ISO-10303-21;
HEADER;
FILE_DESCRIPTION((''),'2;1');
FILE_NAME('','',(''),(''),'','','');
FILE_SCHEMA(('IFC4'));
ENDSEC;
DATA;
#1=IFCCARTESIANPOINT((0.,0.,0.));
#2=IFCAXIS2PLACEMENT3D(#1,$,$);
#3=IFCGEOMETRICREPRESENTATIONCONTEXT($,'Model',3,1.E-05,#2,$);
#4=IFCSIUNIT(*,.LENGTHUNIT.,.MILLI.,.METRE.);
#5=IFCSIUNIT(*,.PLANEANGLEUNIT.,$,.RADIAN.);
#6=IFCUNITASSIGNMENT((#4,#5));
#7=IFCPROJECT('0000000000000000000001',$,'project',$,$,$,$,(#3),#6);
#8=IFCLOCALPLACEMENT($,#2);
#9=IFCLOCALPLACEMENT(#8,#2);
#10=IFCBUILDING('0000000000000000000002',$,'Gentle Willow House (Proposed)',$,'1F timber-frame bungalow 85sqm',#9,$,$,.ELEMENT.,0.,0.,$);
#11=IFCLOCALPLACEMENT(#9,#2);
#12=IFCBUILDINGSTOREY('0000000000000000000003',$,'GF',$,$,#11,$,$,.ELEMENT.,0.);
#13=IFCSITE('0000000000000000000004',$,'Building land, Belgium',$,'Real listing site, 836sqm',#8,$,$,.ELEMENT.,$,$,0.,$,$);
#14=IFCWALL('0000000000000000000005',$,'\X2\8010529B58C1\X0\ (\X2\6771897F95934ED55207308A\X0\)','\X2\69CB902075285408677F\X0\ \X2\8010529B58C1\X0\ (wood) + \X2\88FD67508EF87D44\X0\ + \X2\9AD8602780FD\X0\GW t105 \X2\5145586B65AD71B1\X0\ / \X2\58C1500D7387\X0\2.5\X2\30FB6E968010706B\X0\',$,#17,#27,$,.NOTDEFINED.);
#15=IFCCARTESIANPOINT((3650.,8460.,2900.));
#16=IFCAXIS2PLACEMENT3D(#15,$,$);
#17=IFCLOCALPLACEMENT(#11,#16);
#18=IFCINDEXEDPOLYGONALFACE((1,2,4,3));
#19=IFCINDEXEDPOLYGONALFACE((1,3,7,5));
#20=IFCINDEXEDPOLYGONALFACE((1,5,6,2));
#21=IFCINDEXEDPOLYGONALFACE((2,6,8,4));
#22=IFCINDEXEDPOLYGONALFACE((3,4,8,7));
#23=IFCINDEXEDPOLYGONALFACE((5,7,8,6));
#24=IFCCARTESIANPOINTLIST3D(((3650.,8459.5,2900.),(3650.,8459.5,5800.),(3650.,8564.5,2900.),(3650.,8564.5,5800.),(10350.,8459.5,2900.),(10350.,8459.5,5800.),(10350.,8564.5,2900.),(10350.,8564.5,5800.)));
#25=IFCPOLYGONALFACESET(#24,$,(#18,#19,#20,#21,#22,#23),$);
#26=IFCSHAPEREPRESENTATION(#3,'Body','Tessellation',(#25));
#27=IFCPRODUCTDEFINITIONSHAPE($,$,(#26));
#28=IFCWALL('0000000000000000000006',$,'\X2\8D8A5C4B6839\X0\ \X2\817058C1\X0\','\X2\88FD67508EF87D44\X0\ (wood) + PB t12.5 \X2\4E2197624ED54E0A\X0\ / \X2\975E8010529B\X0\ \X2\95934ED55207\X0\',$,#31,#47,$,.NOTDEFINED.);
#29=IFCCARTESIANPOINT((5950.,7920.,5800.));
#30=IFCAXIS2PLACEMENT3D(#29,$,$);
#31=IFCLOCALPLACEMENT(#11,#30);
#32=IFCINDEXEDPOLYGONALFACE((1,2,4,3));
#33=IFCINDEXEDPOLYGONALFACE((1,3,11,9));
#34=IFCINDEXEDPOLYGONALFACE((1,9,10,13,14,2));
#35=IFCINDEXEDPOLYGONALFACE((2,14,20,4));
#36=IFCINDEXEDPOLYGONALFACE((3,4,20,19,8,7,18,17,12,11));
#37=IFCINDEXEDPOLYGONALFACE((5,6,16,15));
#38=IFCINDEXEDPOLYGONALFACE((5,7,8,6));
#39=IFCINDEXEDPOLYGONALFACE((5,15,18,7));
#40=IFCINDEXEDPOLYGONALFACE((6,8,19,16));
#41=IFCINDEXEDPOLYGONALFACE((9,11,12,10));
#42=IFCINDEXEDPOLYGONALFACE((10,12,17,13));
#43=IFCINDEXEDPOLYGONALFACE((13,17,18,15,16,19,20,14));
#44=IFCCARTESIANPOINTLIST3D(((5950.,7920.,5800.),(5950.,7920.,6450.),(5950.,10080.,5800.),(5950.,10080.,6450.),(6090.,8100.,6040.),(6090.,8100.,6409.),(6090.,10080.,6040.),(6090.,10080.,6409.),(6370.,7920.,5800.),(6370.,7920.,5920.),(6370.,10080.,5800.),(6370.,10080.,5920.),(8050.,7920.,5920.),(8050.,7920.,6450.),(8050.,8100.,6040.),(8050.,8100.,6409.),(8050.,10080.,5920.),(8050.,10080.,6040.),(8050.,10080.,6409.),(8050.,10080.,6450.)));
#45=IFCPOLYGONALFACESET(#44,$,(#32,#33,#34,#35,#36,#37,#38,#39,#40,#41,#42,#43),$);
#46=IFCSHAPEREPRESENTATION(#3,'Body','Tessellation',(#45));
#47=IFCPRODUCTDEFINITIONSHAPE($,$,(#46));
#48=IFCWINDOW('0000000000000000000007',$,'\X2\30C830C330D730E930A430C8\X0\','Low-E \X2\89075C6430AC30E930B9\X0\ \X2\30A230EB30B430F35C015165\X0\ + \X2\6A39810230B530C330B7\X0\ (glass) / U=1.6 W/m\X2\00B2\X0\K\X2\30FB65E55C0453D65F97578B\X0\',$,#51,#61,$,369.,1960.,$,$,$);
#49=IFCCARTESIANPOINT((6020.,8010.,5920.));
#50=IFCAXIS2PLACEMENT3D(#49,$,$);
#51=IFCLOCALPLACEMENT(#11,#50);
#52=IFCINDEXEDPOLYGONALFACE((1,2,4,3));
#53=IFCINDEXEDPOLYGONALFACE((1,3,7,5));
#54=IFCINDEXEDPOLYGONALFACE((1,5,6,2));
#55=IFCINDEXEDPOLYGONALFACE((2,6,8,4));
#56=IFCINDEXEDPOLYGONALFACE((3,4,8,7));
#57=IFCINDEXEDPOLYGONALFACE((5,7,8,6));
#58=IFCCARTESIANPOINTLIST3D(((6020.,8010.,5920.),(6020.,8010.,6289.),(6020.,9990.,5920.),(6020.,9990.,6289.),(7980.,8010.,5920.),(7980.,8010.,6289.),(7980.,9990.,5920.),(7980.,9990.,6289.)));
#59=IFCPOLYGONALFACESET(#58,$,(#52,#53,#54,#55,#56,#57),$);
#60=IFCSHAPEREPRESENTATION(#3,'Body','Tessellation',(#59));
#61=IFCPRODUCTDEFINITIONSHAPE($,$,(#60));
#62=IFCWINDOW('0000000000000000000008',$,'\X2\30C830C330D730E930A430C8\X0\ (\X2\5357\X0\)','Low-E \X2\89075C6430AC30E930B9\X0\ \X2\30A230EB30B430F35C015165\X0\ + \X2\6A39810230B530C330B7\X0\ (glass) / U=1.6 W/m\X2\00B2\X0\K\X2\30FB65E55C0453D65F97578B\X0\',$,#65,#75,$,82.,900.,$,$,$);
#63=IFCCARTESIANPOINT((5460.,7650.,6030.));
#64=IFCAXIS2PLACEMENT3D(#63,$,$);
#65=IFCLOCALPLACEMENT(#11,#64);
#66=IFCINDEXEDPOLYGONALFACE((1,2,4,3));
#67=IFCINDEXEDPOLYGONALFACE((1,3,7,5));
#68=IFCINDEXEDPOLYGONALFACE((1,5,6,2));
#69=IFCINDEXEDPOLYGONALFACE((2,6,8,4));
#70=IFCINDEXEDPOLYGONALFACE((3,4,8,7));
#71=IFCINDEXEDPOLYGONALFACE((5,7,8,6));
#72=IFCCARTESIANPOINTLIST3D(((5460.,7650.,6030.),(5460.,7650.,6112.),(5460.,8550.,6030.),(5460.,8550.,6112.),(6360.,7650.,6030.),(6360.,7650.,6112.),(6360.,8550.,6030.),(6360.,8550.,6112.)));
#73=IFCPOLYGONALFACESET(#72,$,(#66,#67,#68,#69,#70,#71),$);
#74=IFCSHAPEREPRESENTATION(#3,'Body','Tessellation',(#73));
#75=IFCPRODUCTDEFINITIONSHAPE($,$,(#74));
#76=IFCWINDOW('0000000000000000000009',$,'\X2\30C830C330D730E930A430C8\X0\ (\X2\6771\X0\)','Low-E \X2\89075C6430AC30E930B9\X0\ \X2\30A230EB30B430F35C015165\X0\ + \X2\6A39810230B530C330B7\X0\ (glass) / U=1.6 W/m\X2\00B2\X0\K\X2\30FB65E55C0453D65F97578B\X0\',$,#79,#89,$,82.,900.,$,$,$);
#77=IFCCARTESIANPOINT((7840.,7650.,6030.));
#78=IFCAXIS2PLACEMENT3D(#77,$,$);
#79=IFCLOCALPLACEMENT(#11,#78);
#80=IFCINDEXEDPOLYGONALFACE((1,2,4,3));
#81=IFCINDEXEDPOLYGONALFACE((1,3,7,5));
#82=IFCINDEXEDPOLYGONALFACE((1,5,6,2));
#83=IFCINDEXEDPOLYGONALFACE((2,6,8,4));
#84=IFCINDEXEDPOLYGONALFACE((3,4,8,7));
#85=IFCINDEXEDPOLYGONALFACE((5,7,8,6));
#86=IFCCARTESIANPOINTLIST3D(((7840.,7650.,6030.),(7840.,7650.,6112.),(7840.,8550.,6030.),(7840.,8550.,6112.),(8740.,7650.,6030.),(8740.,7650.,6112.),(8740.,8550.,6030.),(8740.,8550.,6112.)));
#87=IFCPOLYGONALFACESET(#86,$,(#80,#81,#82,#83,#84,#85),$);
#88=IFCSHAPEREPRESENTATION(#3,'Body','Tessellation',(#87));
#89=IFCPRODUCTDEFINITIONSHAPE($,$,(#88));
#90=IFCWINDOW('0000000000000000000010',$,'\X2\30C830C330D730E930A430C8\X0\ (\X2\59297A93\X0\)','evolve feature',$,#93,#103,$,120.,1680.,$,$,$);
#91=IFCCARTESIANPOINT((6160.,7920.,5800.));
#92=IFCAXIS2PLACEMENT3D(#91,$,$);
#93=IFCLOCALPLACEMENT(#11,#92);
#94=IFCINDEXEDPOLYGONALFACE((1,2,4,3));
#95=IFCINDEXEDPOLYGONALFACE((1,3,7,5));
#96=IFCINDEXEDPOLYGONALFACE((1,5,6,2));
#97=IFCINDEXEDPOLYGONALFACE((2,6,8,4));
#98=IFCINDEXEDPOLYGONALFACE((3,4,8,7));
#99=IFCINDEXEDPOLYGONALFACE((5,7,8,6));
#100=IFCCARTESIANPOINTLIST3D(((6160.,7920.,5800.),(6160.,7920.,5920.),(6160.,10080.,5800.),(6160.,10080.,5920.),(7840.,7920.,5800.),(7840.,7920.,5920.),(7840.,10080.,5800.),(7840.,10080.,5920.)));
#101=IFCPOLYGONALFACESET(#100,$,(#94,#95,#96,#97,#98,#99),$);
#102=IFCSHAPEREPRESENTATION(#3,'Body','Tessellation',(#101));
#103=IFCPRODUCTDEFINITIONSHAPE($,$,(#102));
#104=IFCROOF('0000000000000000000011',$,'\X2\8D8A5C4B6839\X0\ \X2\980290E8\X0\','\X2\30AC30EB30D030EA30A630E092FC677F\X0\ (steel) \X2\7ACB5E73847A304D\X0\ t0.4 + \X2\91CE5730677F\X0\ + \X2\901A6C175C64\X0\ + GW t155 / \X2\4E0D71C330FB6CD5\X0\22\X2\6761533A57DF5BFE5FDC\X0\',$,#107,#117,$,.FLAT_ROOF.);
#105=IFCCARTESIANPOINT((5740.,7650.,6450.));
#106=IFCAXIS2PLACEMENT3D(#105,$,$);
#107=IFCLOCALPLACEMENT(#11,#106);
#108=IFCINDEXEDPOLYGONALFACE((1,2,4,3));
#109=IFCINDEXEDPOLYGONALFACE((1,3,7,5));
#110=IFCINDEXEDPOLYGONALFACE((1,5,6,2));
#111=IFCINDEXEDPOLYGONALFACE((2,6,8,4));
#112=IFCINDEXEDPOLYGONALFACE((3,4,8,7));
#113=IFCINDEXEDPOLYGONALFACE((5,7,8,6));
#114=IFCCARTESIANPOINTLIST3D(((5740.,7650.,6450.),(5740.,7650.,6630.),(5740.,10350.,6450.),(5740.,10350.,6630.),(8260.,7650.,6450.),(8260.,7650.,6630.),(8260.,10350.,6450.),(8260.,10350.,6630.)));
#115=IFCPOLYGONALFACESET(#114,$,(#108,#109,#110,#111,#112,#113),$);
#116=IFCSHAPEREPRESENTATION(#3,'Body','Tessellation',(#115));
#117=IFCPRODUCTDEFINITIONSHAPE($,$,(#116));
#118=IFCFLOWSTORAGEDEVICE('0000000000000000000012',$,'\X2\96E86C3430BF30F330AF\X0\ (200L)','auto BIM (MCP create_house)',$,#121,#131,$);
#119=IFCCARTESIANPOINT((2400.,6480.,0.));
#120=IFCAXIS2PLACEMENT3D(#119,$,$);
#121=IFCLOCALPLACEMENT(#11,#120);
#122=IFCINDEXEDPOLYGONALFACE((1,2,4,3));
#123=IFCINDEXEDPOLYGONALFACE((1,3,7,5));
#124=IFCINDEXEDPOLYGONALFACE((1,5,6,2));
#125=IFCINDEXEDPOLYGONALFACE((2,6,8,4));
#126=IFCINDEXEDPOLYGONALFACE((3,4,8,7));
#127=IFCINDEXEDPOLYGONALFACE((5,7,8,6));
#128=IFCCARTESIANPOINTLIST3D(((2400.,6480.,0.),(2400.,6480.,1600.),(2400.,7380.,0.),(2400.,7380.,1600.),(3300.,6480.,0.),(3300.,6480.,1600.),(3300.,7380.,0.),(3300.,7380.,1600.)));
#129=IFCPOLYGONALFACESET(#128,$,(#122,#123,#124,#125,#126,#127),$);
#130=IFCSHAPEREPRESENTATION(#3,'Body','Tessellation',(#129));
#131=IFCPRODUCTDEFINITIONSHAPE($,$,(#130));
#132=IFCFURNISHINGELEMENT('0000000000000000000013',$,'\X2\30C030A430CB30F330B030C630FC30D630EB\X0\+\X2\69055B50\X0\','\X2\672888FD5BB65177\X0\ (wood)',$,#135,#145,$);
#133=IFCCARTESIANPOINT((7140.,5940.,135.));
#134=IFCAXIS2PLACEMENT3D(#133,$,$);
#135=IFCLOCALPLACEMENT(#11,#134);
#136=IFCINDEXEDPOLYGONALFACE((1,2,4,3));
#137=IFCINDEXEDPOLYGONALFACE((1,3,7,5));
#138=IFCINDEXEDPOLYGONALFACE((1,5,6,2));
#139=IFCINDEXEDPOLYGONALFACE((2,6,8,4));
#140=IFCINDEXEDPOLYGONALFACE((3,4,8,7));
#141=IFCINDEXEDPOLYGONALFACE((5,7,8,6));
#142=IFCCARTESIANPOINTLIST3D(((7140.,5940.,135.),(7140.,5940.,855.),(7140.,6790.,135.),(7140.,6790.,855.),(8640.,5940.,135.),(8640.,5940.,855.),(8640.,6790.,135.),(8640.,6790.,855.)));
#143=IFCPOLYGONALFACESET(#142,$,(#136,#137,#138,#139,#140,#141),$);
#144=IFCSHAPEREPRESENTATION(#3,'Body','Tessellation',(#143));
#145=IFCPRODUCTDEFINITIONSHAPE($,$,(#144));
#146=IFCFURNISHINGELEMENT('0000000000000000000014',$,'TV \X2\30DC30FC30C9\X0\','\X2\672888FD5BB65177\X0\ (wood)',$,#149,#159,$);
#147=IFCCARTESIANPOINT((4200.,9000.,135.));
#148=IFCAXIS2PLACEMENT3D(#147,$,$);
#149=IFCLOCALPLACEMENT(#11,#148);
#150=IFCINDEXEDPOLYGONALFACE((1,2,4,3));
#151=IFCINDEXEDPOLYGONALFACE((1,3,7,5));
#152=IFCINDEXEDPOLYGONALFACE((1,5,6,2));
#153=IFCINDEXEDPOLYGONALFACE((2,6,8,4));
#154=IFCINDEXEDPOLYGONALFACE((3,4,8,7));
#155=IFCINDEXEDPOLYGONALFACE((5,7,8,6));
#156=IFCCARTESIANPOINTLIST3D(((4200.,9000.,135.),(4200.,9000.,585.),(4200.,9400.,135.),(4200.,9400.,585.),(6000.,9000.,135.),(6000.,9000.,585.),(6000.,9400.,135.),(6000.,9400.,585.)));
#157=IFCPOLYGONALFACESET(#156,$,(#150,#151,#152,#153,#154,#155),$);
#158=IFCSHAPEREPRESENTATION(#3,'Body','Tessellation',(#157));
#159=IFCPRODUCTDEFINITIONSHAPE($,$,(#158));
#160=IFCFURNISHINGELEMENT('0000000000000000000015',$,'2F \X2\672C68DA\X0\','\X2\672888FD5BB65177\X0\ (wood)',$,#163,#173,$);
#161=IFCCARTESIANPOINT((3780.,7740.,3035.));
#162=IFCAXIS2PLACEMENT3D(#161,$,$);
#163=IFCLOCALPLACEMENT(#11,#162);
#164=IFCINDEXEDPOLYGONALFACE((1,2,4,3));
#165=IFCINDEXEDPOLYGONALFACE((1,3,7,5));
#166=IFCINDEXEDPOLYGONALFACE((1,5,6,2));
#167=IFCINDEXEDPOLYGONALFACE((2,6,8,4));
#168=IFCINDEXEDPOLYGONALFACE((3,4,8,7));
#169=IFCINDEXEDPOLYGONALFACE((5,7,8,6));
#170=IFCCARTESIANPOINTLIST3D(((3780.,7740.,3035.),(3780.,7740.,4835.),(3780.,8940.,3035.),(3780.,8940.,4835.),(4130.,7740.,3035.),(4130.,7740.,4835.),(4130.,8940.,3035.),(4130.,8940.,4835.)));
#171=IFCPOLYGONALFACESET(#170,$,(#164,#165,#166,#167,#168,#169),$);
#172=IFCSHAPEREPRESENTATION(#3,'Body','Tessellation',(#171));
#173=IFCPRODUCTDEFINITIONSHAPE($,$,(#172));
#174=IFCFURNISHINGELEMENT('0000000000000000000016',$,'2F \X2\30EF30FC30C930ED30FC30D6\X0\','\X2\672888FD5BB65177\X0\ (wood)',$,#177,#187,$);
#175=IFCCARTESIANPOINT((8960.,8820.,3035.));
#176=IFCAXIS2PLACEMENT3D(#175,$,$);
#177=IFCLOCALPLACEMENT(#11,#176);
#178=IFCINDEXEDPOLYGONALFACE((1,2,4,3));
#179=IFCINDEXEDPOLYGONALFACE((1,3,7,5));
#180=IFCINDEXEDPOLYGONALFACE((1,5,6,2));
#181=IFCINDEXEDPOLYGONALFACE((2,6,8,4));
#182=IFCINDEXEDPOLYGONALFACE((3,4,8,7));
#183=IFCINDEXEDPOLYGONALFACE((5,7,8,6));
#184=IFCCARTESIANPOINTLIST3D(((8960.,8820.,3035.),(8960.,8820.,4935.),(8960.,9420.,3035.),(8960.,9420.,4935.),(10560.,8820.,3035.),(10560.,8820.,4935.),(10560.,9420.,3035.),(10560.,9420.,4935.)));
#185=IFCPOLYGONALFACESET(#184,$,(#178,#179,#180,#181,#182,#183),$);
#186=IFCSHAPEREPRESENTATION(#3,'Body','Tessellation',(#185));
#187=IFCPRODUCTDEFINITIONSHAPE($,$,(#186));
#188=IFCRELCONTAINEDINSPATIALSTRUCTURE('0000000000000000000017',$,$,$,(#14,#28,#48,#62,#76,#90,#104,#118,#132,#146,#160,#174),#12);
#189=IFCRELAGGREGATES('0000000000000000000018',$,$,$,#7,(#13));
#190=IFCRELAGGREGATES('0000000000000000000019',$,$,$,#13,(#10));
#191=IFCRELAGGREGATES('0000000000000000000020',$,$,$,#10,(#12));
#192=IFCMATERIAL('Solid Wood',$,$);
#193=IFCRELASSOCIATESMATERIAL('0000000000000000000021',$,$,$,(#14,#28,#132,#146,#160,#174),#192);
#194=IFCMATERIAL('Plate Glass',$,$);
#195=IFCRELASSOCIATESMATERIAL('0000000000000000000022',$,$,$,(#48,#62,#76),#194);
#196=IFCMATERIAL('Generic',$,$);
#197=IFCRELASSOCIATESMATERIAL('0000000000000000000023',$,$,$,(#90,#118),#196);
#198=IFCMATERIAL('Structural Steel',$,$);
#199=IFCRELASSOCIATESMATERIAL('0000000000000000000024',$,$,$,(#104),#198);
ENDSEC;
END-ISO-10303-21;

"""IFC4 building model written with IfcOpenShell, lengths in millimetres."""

from ifc_helpers import new_model, si_unit, frame, frame_2d, origin, place, context, project, spatial, rectangle, extrude, material, element, fill, save


model = new_model("IFC4")

# Units and contexts
model_context = context("Model", 3, precision=1e-05, world=origin())
ifc_project = project(units=[si_unit("LENGTHUNIT", "METRE", prefix="MILLI"), si_unit("PLANEANGLEUNIT", "RADIAN")], contexts=[model_context])

# Site, building, storey
site_placement = place(None, origin())
site = spatial("IfcSite", under=ifc_project, at=site_placement, Name="Building land, Belgium", ObjectType="Real listing site, 836sqm", CompositionType="ELEMENT", RefElevation=0.0)
building_placement = place(site_placement, origin())
building = spatial("IfcBuilding", under=site, at=building_placement, Name="Gentle Willow House (Proposed)", ObjectType="1F timber-frame bungalow 85sqm", CompositionType="ELEMENT", ElevationOfRefHeight=0.0, ElevationOfTerrain=0.0)
storey_placement = place(building_placement, origin())
storey = spatial("IfcBuildingStorey", under=building, at=storey_placement, Name="GF", CompositionType="ELEMENT", Elevation=0.0)

# Wall
ifc_material_1 = material(Name="Solid Wood")
wall_1_placement = place(storey_placement, frame((3650.0, 8460.0, 2900.0)))
element("IfcWall", 1, at=wall_1_placement, inside=storey, material=ifc_material_1, Name="耐力壁 (東西間仕切り)", Description="構造用合板 耐力壁 (wood) + 製材軸組 + 高性能GW t105 充填断熱 / 壁倍率2.5・準耐火", PredefinedType="NOTDEFINED", context=model_context, shape_type="SweptSolid", body=[
    extrude(rectangle(XDim=6700.0, YDim=105.0, at=frame_2d((3350.0, 52.0))), frame((3650.0, 8460.0, 2900.0)), (0.0, 0.0, 1.0), 2900.0),
])

# Wall, openings, windows
wall_2_placement = place(storey_placement, frame((5950.0, 7920.0, 5800.0)))
wall_2 = element("IfcWall", 2, at=wall_2_placement, inside=storey, material=ifc_material_1, Name="越屋根 腰壁", Description="製材軸組 (wood) + PB t12.5 両面仕上 / 非耐力 間仕切", PredefinedType="NOTDEFINED", context=model_context, shape_type="SweptSolid", body=[
    extrude(rectangle(XDim=2100.0, YDim=2160.0, at=frame_2d((1050.0, 1080.0))), frame((5950.0, 7920.0, 5800.0)), (0.0, 0.0, 1.0), 650.0),
])
opening_1_placement = place(storey_placement, frame((6020.0, 8010.0, 5920.0)))
opening_1 = element("IfcOpeningElement", 3, at=opening_1_placement, cuts=wall_2, PredefinedType="NOTDEFINED", context=model_context, shape_type="SweptSolid", body=[
    extrude(rectangle(XDim=1960.0, YDim=1980.0, at=frame_2d((980.0, 990.0))), frame((6020.0, 8010.0, 5920.0)), (0.0, 0.0, 1.0), 369.0),
])
opening_2_placement = place(storey_placement, frame((5460.0, 7650.0, 6030.0)))
opening_2 = element("IfcOpeningElement", 4, at=opening_2_placement, cuts=wall_2, PredefinedType="NOTDEFINED", context=model_context, shape_type="SweptSolid", body=[
    extrude(rectangle(XDim=900.0, YDim=900.0, at=frame_2d((450.0, 450.0))), frame((5460.0, 7650.0, 6030.0)), (0.0, 0.0, 1.0), 82.0),
])
opening_3_placement = place(storey_placement, frame((7840.0, 7650.0, 6030.0)))
opening_3 = element("IfcOpeningElement", 5, at=opening_3_placement, cuts=wall_2, PredefinedType="NOTDEFINED", context=model_context, shape_type="SweptSolid", body=[
    extrude(rectangle(XDim=900.0, YDim=900.0, at=frame_2d((450.0, 450.0))), frame((7840.0, 7650.0, 6030.0)), (0.0, 0.0, 1.0), 82.0),
])
opening_4_placement = place(storey_placement, frame((6160.0, 7920.0, 5800.0)))
opening_4 = element("IfcOpeningElement", 6, at=opening_4_placement, cuts=wall_2, PredefinedType="NOTDEFINED", context=model_context, shape_type="SweptSolid", body=[
    extrude(rectangle(XDim=1680.0, YDim=2160.0, at=frame_2d((840.0, 1080.0))), frame((6160.0, 7920.0, 5800.0)), (0.0, 0.0, 1.0), 120.0),
])
ifc_material_2 = material(Name="Plate Glass")
window_1_placement = place(storey_placement, frame((6020.0, 8010.0, 5920.0)))
window_1 = element("IfcWindow", 7, at=window_1_placement, inside=storey, material=ifc_material_2, Name="トップライト", Description="Low-E 複層ガラス アルゴン封入 + 樹脂サッシ (glass) / U=1.6 W/m²K・日射取得型", OverallHeight=369.0, OverallWidth=1960.0, context=model_context, shape_type="SweptSolid", body=[
    extrude(rectangle(XDim=1960.0, YDim=1980.0, at=frame_2d((980.0, 990.0))), frame((6020.0, 8010.0, 5920.0)), (0.0, 0.0, 1.0), 369.0),
])
fill(opening_1, window_1)
window_2_placement = place(storey_placement, frame((5460.0, 7650.0, 6030.0)))
window_2 = element("IfcWindow", 8, at=window_2_placement, inside=storey, material=ifc_material_2, Name="トップライト (南)", Description="Low-E 複層ガラス アルゴン封入 + 樹脂サッシ (glass) / U=1.6 W/m²K・日射取得型", OverallHeight=82.0, OverallWidth=900.0, context=model_context, shape_type="SweptSolid", body=[
    extrude(rectangle(XDim=900.0, YDim=900.0, at=frame_2d((450.0, 450.0))), frame((5460.0, 7650.0, 6030.0)), (0.0, 0.0, 1.0), 82.0),
])
fill(opening_2, window_2)
window_3_placement = place(storey_placement, frame((7840.0, 7650.0, 6030.0)))
window_3 = element("IfcWindow", 9, at=window_3_placement, inside=storey, material=ifc_material_2, Name="トップライト (東)", Description="Low-E 複層ガラス アルゴン封入 + 樹脂サッシ (glass) / U=1.6 W/m²K・日射取得型", OverallHeight=82.0, OverallWidth=900.0, context=model_context, shape_type="SweptSolid", body=[
    extrude(rectangle(XDim=900.0, YDim=900.0, at=frame_2d((450.0, 450.0))), frame((7840.0, 7650.0, 6030.0)), (0.0, 0.0, 1.0), 82.0),
])
fill(opening_3, window_3)
ifc_material_3 = material(Name="Generic")
window_4_placement = place(storey_placement, frame((6160.0, 7920.0, 5800.0)))
window_4 = element("IfcWindow", 10, at=window_4_placement, inside=storey, material=ifc_material_3, Name="トップライト (天窓)", Description="evolve feature", OverallHeight=120.0, OverallWidth=1680.0, context=model_context, shape_type="SweptSolid", body=[
    extrude(rectangle(XDim=1680.0, YDim=2160.0, at=frame_2d((840.0, 1080.0))), frame((6160.0, 7920.0, 5800.0)), (0.0, 0.0, 1.0), 120.0),
])
fill(opening_4, window_4)

# Roof
ifc_material_4 = material(Name="Structural Steel")
roof_placement = place(storey_placement, frame((5740.0, 7650.0, 6450.0)))
element("IfcRoof", 11, at=roof_placement, inside=storey, material=ifc_material_4, Name="越屋根 頂部", Description="ガルバリウム鋼板 (steel) 立平葺き t0.4 + 野地板 + 通気層 + GW t155 / 不燃・法22条区域対応", PredefinedType="FLAT_ROOF", context=model_context, shape_type="SweptSolid", body=[
    extrude(rectangle(XDim=2520.0, YDim=2700.0, at=frame_2d((1260.0, 1350.0))), frame((5740.0, 7650.0, 6450.0)), (0.0, 0.0, 1.0), 180.0),
])

# Flow storage device
flow_storage_device_placement = place(storey_placement, frame((2400.0, 6480.0, 0.0)))
element("IfcFlowStorageDevice", 12, at=flow_storage_device_placement, inside=storey, material=ifc_material_3, Name="雨水タンク (200L)", Description="auto BIM (MCP create_house)", context=model_context, shape_type="SweptSolid", body=[
    extrude(rectangle(XDim=900.0, YDim=900.0, at=frame_2d((450.0, 450.0))), frame((2400.0, 6480.0, 0.0)), (0.0, 0.0, 1.0), 1600.0),
])

# Furnishing elements
furnishing_1_placement = place(storey_placement, frame((7140.0, 5940.0, 135.0)))
element("IfcFurnishingElement", 13, at=furnishing_1_placement, inside=storey, material=ifc_material_1, Name="ダイニングテーブル+椅子", Description="木製家具 (wood)", context=model_context, shape_type="SweptSolid", body=[
    extrude(rectangle(XDim=1500.0, YDim=850.0, at=frame_2d((750.0, 425.0))), frame((7140.0, 5940.0, 135.0)), (0.0, 0.0, 1.0), 720.0),
])
furnishing_2_placement = place(storey_placement, frame((4200.0, 9000.0, 135.0)))
element("IfcFurnishingElement", 14, at=furnishing_2_placement, inside=storey, material=ifc_material_1, Name="TV ボード", Description="木製家具 (wood)", context=model_context, shape_type="SweptSolid", body=[
    extrude(rectangle(XDim=1800.0, YDim=400.0, at=frame_2d((900.0, 200.0))), frame((4200.0, 9000.0, 135.0)), (0.0, 0.0, 1.0), 450.0),
])
furnishing_3_placement = place(storey_placement, frame((3780.0, 7740.0, 3035.0)))
element("IfcFurnishingElement", 15, at=furnishing_3_placement, inside=storey, material=ifc_material_1, Name="2F 本棚", Description="木製家具 (wood)", context=model_context, shape_type="SweptSolid", body=[
    extrude(rectangle(XDim=350.0, YDim=1200.0, at=frame_2d((175.0, 600.0))), frame((3780.0, 7740.0, 3035.0)), (0.0, 0.0, 1.0), 1800.0),
])
furnishing_4_placement = place(storey_placement, frame((8960.0, 8820.0, 3035.0)))
element("IfcFurnishingElement", 16, at=furnishing_4_placement, inside=storey, material=ifc_material_1, Name="2F ワードローブ", Description="木製家具 (wood)", context=model_context, shape_type="SweptSolid", body=[
    extrude(rectangle(XDim=1600.0, YDim=600.0, at=frame_2d((800.0, 300.0))), frame((8960.0, 8820.0, 3035.0)), (0.0, 0.0, 1.0), 1900.0),
])

save(model, "model.ifc")
